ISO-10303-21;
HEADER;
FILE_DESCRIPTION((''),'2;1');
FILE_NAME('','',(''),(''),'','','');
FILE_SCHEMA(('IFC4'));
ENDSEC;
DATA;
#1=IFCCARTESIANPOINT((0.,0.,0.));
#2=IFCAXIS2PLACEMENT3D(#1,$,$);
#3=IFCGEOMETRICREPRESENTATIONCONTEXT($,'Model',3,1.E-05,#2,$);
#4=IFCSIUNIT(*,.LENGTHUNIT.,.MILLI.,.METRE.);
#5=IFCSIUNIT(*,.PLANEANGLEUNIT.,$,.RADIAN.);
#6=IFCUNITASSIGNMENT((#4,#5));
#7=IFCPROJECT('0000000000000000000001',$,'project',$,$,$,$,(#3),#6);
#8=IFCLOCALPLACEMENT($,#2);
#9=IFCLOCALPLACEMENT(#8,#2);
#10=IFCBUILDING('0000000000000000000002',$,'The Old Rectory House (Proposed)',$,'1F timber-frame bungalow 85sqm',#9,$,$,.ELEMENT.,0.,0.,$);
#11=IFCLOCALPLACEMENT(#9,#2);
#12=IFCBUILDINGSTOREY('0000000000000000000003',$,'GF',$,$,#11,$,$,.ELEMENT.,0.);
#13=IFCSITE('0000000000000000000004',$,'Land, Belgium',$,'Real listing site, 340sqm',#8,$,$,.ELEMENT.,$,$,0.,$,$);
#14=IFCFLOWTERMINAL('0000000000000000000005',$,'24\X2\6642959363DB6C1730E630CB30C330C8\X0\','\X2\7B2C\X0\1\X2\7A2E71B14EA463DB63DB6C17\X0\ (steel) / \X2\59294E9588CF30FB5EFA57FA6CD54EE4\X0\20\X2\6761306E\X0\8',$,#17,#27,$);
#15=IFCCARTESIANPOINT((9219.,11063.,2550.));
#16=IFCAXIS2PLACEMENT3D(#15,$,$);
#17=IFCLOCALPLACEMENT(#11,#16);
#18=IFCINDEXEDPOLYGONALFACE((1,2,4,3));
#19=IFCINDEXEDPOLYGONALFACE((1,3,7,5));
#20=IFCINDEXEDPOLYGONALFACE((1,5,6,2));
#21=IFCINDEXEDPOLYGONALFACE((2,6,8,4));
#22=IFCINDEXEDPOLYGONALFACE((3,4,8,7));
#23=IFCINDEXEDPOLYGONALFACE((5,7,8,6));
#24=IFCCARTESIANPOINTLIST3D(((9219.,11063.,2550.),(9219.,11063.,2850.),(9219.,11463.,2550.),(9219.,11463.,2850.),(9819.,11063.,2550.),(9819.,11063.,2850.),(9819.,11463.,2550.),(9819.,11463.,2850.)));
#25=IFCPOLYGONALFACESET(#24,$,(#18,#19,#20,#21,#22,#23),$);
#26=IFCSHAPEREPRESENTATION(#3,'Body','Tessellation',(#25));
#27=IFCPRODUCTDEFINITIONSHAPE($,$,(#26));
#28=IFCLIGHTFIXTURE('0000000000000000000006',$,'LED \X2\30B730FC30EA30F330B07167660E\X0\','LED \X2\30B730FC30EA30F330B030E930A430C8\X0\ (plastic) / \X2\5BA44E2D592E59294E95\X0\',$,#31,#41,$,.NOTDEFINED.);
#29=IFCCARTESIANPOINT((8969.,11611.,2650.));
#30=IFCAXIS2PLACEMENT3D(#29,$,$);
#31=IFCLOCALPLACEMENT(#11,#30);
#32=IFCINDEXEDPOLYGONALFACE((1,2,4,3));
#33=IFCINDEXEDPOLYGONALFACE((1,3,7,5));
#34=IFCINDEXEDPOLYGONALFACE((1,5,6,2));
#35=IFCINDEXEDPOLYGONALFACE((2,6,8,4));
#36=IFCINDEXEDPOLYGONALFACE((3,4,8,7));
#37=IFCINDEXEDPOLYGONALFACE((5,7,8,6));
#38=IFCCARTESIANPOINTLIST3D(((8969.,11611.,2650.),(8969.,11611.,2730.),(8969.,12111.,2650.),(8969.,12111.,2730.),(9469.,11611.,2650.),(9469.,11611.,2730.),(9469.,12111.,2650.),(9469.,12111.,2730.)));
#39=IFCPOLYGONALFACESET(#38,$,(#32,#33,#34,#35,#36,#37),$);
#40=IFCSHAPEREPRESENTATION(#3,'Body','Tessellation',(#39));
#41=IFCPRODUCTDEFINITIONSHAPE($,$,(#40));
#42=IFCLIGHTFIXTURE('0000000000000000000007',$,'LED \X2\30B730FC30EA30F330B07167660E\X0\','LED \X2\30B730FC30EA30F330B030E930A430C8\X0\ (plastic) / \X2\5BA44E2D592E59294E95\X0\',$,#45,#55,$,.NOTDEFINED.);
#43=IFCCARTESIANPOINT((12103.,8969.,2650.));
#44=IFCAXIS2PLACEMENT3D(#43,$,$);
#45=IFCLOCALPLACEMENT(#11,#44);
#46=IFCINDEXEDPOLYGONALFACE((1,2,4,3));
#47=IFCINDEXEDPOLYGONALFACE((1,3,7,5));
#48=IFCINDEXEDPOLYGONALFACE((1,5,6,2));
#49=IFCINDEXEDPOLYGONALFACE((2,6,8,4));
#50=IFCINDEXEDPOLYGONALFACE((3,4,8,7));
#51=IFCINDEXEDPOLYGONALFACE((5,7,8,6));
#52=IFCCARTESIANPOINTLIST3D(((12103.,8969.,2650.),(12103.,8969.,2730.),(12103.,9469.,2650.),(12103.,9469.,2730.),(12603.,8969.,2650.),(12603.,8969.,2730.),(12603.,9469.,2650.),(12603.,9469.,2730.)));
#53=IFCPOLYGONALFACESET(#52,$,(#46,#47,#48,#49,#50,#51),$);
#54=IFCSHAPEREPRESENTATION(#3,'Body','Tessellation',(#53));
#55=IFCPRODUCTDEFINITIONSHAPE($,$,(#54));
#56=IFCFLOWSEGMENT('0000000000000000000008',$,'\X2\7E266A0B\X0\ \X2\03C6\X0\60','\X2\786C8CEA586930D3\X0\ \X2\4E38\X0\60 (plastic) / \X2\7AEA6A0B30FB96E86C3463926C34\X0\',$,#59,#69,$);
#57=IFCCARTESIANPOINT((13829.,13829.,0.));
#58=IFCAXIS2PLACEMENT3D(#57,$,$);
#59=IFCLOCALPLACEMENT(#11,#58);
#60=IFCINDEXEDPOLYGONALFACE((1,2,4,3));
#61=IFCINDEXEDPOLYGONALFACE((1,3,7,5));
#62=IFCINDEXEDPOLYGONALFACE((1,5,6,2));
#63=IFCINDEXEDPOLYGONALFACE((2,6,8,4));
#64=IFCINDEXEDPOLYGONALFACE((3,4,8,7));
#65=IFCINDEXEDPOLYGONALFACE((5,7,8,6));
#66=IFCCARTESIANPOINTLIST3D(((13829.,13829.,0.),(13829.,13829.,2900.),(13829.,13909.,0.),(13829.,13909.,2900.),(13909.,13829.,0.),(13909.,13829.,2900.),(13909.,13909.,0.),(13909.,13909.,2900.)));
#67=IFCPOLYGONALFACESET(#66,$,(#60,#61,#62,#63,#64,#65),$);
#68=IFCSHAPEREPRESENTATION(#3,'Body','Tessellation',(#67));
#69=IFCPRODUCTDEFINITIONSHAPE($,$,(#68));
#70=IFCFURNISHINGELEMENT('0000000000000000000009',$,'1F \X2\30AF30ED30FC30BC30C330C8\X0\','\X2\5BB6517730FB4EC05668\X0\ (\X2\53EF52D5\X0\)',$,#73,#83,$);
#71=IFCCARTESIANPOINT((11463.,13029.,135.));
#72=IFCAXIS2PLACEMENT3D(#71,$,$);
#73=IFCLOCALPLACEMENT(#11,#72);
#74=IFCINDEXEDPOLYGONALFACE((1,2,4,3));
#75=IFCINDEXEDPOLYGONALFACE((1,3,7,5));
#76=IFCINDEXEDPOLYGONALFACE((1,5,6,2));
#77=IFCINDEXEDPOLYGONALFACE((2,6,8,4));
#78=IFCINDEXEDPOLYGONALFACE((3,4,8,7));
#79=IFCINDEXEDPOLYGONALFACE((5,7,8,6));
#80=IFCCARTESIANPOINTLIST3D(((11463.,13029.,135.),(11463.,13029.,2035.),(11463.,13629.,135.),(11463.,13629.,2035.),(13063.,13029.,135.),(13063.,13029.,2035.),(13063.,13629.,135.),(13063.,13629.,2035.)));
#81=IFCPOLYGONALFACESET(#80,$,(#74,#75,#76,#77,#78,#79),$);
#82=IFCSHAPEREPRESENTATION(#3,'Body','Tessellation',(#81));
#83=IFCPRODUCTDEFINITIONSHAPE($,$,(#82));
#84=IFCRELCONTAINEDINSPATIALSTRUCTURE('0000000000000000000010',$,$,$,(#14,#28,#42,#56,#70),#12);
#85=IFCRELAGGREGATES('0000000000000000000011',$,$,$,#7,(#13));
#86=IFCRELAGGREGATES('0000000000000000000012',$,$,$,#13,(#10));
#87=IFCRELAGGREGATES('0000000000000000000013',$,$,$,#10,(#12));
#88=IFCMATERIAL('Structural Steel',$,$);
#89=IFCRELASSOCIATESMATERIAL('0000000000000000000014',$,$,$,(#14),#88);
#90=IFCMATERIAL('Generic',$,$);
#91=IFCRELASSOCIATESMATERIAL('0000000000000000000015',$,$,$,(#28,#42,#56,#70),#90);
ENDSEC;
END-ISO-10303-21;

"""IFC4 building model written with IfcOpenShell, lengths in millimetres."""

from ifc_helpers import new_model, si_unit, frame, frame_2d, origin, place, context, project, spatial, rectangle, extrude, material, element, save


model = new_model("IFC4")

# Units and contexts
model_context = context("Model", 3, precision=1e-05, world=origin())
ifc_project = project(units=[si_unit("LENGTHUNIT", "METRE", prefix="MILLI"), si_unit("PLANEANGLEUNIT", "RADIAN")], contexts=[model_context])

# Site, building, storey
site_placement = place(None, origin())
site = spatial("IfcSite", under=ifc_project, at=site_placement, Name="Land, Belgium", ObjectType="Real listing site, 340sqm", CompositionType="ELEMENT", RefElevation=0.0)
building_placement = place(site_placement, origin())
building = spatial("IfcBuilding", under=site, at=building_placement, Name="The Old Rectory House (Proposed)", ObjectType="1F timber-frame bungalow 85sqm", CompositionType="ELEMENT", ElevationOfRefHeight=0.0, ElevationOfTerrain=0.0)
storey_placement = place(building_placement, origin())
storey = spatial("IfcBuildingStorey", under=building, at=storey_placement, Name="GF", CompositionType="ELEMENT", Elevation=0.0)

# Shared definitions
ifc_material_1 = material(Name="Generic")

# Flow terminal
ifc_material_2 = material(Name="Structural Steel")
flow_terminal_placement = place(storey_placement, frame((9219.0, 11063.0, 2550.0)))
element("IfcFlowTerminal", 1, at=flow_terminal_placement, inside=storey, material=ifc_material_2, Name="24時間換気ユニット", Description="第1種熱交換換気 (steel) / 天井裏・建基法令20条の8", context=model_context, shape_type="SweptSolid", body=[
    extrude(rectangle(XDim=600.0, YDim=400.0, at=frame_2d((300.0, 200.0))), frame((9219.0, 11063.0, 2550.0)), (0.0, 0.0, 1.0), 300.0),
])

# Light fixtures
light_fixture_1_placement = place(storey_placement, frame((8969.0, 11611.0, 2650.0)))
element("IfcLightFixture", 2, at=light_fixture_1_placement, inside=storey, material=ifc_material_1, Name="LED シーリング照明", Description="LED シーリングライト (plastic) / 室中央天井", PredefinedType="NOTDEFINED", context=model_context, shape_type="SweptSolid", body=[
    extrude(rectangle(XDim=500.0, YDim=500.0, at=frame_2d((250.0, 250.0))), frame((8969.0, 11611.0, 2650.0)), (0.0, 0.0, 1.0), 80.0),
])
light_fixture_2_placement = place(storey_placement, frame((12103.0, 8969.0, 2650.0)))
element("IfcLightFixture", 3, at=light_fixture_2_placement, inside=storey, material=ifc_material_1, Name="LED シーリング照明", Description="LED シーリングライト (plastic) / 室中央天井", PredefinedType="NOTDEFINED", context=model_context, shape_type="SweptSolid", body=[
    extrude(rectangle(XDim=500.0, YDim=500.0, at=frame_2d((250.0, 250.0))), frame((12103.0, 8969.0, 2650.0)), (0.0, 0.0, 1.0), 80.0),
])

# Flow segment
flow_segment_placement = place(storey_placement, frame((13829.0, 13829.0, 0.0)))
element("IfcFlowSegment", 4, at=flow_segment_placement, inside=storey, material=ifc_material_1, Name="縦樋 φ60", Description="硬質塩ビ 丸60 (plastic) / 竪樋・雨水排水", context=model_context, shape_type="SweptSolid", body=[
    extrude(rectangle(XDim=80.0, YDim=80.0, at=frame_2d((40.0, 40.0))), frame((13829.0, 13829.0, 0.0)), (0.0, 0.0, 1.0), 2900.0),
])

# Furnishing element
furnishing_placement = place(storey_placement, frame((11463.0, 13029.0, 135.0)))
element("IfcFurnishingElement", 5, at=furnishing_placement, inside=storey, material=ifc_material_1, Name="1F クローゼット", Description="家具・什器 (可動)", context=model_context, shape_type="SweptSolid", body=[
    extrude(rectangle(XDim=1600.0, YDim=600.0, at=frame_2d((800.0, 300.0))), frame((11463.0, 13029.0, 135.0)), (0.0, 0.0, 1.0), 1900.0),
])

save(model, "model.ifc")
